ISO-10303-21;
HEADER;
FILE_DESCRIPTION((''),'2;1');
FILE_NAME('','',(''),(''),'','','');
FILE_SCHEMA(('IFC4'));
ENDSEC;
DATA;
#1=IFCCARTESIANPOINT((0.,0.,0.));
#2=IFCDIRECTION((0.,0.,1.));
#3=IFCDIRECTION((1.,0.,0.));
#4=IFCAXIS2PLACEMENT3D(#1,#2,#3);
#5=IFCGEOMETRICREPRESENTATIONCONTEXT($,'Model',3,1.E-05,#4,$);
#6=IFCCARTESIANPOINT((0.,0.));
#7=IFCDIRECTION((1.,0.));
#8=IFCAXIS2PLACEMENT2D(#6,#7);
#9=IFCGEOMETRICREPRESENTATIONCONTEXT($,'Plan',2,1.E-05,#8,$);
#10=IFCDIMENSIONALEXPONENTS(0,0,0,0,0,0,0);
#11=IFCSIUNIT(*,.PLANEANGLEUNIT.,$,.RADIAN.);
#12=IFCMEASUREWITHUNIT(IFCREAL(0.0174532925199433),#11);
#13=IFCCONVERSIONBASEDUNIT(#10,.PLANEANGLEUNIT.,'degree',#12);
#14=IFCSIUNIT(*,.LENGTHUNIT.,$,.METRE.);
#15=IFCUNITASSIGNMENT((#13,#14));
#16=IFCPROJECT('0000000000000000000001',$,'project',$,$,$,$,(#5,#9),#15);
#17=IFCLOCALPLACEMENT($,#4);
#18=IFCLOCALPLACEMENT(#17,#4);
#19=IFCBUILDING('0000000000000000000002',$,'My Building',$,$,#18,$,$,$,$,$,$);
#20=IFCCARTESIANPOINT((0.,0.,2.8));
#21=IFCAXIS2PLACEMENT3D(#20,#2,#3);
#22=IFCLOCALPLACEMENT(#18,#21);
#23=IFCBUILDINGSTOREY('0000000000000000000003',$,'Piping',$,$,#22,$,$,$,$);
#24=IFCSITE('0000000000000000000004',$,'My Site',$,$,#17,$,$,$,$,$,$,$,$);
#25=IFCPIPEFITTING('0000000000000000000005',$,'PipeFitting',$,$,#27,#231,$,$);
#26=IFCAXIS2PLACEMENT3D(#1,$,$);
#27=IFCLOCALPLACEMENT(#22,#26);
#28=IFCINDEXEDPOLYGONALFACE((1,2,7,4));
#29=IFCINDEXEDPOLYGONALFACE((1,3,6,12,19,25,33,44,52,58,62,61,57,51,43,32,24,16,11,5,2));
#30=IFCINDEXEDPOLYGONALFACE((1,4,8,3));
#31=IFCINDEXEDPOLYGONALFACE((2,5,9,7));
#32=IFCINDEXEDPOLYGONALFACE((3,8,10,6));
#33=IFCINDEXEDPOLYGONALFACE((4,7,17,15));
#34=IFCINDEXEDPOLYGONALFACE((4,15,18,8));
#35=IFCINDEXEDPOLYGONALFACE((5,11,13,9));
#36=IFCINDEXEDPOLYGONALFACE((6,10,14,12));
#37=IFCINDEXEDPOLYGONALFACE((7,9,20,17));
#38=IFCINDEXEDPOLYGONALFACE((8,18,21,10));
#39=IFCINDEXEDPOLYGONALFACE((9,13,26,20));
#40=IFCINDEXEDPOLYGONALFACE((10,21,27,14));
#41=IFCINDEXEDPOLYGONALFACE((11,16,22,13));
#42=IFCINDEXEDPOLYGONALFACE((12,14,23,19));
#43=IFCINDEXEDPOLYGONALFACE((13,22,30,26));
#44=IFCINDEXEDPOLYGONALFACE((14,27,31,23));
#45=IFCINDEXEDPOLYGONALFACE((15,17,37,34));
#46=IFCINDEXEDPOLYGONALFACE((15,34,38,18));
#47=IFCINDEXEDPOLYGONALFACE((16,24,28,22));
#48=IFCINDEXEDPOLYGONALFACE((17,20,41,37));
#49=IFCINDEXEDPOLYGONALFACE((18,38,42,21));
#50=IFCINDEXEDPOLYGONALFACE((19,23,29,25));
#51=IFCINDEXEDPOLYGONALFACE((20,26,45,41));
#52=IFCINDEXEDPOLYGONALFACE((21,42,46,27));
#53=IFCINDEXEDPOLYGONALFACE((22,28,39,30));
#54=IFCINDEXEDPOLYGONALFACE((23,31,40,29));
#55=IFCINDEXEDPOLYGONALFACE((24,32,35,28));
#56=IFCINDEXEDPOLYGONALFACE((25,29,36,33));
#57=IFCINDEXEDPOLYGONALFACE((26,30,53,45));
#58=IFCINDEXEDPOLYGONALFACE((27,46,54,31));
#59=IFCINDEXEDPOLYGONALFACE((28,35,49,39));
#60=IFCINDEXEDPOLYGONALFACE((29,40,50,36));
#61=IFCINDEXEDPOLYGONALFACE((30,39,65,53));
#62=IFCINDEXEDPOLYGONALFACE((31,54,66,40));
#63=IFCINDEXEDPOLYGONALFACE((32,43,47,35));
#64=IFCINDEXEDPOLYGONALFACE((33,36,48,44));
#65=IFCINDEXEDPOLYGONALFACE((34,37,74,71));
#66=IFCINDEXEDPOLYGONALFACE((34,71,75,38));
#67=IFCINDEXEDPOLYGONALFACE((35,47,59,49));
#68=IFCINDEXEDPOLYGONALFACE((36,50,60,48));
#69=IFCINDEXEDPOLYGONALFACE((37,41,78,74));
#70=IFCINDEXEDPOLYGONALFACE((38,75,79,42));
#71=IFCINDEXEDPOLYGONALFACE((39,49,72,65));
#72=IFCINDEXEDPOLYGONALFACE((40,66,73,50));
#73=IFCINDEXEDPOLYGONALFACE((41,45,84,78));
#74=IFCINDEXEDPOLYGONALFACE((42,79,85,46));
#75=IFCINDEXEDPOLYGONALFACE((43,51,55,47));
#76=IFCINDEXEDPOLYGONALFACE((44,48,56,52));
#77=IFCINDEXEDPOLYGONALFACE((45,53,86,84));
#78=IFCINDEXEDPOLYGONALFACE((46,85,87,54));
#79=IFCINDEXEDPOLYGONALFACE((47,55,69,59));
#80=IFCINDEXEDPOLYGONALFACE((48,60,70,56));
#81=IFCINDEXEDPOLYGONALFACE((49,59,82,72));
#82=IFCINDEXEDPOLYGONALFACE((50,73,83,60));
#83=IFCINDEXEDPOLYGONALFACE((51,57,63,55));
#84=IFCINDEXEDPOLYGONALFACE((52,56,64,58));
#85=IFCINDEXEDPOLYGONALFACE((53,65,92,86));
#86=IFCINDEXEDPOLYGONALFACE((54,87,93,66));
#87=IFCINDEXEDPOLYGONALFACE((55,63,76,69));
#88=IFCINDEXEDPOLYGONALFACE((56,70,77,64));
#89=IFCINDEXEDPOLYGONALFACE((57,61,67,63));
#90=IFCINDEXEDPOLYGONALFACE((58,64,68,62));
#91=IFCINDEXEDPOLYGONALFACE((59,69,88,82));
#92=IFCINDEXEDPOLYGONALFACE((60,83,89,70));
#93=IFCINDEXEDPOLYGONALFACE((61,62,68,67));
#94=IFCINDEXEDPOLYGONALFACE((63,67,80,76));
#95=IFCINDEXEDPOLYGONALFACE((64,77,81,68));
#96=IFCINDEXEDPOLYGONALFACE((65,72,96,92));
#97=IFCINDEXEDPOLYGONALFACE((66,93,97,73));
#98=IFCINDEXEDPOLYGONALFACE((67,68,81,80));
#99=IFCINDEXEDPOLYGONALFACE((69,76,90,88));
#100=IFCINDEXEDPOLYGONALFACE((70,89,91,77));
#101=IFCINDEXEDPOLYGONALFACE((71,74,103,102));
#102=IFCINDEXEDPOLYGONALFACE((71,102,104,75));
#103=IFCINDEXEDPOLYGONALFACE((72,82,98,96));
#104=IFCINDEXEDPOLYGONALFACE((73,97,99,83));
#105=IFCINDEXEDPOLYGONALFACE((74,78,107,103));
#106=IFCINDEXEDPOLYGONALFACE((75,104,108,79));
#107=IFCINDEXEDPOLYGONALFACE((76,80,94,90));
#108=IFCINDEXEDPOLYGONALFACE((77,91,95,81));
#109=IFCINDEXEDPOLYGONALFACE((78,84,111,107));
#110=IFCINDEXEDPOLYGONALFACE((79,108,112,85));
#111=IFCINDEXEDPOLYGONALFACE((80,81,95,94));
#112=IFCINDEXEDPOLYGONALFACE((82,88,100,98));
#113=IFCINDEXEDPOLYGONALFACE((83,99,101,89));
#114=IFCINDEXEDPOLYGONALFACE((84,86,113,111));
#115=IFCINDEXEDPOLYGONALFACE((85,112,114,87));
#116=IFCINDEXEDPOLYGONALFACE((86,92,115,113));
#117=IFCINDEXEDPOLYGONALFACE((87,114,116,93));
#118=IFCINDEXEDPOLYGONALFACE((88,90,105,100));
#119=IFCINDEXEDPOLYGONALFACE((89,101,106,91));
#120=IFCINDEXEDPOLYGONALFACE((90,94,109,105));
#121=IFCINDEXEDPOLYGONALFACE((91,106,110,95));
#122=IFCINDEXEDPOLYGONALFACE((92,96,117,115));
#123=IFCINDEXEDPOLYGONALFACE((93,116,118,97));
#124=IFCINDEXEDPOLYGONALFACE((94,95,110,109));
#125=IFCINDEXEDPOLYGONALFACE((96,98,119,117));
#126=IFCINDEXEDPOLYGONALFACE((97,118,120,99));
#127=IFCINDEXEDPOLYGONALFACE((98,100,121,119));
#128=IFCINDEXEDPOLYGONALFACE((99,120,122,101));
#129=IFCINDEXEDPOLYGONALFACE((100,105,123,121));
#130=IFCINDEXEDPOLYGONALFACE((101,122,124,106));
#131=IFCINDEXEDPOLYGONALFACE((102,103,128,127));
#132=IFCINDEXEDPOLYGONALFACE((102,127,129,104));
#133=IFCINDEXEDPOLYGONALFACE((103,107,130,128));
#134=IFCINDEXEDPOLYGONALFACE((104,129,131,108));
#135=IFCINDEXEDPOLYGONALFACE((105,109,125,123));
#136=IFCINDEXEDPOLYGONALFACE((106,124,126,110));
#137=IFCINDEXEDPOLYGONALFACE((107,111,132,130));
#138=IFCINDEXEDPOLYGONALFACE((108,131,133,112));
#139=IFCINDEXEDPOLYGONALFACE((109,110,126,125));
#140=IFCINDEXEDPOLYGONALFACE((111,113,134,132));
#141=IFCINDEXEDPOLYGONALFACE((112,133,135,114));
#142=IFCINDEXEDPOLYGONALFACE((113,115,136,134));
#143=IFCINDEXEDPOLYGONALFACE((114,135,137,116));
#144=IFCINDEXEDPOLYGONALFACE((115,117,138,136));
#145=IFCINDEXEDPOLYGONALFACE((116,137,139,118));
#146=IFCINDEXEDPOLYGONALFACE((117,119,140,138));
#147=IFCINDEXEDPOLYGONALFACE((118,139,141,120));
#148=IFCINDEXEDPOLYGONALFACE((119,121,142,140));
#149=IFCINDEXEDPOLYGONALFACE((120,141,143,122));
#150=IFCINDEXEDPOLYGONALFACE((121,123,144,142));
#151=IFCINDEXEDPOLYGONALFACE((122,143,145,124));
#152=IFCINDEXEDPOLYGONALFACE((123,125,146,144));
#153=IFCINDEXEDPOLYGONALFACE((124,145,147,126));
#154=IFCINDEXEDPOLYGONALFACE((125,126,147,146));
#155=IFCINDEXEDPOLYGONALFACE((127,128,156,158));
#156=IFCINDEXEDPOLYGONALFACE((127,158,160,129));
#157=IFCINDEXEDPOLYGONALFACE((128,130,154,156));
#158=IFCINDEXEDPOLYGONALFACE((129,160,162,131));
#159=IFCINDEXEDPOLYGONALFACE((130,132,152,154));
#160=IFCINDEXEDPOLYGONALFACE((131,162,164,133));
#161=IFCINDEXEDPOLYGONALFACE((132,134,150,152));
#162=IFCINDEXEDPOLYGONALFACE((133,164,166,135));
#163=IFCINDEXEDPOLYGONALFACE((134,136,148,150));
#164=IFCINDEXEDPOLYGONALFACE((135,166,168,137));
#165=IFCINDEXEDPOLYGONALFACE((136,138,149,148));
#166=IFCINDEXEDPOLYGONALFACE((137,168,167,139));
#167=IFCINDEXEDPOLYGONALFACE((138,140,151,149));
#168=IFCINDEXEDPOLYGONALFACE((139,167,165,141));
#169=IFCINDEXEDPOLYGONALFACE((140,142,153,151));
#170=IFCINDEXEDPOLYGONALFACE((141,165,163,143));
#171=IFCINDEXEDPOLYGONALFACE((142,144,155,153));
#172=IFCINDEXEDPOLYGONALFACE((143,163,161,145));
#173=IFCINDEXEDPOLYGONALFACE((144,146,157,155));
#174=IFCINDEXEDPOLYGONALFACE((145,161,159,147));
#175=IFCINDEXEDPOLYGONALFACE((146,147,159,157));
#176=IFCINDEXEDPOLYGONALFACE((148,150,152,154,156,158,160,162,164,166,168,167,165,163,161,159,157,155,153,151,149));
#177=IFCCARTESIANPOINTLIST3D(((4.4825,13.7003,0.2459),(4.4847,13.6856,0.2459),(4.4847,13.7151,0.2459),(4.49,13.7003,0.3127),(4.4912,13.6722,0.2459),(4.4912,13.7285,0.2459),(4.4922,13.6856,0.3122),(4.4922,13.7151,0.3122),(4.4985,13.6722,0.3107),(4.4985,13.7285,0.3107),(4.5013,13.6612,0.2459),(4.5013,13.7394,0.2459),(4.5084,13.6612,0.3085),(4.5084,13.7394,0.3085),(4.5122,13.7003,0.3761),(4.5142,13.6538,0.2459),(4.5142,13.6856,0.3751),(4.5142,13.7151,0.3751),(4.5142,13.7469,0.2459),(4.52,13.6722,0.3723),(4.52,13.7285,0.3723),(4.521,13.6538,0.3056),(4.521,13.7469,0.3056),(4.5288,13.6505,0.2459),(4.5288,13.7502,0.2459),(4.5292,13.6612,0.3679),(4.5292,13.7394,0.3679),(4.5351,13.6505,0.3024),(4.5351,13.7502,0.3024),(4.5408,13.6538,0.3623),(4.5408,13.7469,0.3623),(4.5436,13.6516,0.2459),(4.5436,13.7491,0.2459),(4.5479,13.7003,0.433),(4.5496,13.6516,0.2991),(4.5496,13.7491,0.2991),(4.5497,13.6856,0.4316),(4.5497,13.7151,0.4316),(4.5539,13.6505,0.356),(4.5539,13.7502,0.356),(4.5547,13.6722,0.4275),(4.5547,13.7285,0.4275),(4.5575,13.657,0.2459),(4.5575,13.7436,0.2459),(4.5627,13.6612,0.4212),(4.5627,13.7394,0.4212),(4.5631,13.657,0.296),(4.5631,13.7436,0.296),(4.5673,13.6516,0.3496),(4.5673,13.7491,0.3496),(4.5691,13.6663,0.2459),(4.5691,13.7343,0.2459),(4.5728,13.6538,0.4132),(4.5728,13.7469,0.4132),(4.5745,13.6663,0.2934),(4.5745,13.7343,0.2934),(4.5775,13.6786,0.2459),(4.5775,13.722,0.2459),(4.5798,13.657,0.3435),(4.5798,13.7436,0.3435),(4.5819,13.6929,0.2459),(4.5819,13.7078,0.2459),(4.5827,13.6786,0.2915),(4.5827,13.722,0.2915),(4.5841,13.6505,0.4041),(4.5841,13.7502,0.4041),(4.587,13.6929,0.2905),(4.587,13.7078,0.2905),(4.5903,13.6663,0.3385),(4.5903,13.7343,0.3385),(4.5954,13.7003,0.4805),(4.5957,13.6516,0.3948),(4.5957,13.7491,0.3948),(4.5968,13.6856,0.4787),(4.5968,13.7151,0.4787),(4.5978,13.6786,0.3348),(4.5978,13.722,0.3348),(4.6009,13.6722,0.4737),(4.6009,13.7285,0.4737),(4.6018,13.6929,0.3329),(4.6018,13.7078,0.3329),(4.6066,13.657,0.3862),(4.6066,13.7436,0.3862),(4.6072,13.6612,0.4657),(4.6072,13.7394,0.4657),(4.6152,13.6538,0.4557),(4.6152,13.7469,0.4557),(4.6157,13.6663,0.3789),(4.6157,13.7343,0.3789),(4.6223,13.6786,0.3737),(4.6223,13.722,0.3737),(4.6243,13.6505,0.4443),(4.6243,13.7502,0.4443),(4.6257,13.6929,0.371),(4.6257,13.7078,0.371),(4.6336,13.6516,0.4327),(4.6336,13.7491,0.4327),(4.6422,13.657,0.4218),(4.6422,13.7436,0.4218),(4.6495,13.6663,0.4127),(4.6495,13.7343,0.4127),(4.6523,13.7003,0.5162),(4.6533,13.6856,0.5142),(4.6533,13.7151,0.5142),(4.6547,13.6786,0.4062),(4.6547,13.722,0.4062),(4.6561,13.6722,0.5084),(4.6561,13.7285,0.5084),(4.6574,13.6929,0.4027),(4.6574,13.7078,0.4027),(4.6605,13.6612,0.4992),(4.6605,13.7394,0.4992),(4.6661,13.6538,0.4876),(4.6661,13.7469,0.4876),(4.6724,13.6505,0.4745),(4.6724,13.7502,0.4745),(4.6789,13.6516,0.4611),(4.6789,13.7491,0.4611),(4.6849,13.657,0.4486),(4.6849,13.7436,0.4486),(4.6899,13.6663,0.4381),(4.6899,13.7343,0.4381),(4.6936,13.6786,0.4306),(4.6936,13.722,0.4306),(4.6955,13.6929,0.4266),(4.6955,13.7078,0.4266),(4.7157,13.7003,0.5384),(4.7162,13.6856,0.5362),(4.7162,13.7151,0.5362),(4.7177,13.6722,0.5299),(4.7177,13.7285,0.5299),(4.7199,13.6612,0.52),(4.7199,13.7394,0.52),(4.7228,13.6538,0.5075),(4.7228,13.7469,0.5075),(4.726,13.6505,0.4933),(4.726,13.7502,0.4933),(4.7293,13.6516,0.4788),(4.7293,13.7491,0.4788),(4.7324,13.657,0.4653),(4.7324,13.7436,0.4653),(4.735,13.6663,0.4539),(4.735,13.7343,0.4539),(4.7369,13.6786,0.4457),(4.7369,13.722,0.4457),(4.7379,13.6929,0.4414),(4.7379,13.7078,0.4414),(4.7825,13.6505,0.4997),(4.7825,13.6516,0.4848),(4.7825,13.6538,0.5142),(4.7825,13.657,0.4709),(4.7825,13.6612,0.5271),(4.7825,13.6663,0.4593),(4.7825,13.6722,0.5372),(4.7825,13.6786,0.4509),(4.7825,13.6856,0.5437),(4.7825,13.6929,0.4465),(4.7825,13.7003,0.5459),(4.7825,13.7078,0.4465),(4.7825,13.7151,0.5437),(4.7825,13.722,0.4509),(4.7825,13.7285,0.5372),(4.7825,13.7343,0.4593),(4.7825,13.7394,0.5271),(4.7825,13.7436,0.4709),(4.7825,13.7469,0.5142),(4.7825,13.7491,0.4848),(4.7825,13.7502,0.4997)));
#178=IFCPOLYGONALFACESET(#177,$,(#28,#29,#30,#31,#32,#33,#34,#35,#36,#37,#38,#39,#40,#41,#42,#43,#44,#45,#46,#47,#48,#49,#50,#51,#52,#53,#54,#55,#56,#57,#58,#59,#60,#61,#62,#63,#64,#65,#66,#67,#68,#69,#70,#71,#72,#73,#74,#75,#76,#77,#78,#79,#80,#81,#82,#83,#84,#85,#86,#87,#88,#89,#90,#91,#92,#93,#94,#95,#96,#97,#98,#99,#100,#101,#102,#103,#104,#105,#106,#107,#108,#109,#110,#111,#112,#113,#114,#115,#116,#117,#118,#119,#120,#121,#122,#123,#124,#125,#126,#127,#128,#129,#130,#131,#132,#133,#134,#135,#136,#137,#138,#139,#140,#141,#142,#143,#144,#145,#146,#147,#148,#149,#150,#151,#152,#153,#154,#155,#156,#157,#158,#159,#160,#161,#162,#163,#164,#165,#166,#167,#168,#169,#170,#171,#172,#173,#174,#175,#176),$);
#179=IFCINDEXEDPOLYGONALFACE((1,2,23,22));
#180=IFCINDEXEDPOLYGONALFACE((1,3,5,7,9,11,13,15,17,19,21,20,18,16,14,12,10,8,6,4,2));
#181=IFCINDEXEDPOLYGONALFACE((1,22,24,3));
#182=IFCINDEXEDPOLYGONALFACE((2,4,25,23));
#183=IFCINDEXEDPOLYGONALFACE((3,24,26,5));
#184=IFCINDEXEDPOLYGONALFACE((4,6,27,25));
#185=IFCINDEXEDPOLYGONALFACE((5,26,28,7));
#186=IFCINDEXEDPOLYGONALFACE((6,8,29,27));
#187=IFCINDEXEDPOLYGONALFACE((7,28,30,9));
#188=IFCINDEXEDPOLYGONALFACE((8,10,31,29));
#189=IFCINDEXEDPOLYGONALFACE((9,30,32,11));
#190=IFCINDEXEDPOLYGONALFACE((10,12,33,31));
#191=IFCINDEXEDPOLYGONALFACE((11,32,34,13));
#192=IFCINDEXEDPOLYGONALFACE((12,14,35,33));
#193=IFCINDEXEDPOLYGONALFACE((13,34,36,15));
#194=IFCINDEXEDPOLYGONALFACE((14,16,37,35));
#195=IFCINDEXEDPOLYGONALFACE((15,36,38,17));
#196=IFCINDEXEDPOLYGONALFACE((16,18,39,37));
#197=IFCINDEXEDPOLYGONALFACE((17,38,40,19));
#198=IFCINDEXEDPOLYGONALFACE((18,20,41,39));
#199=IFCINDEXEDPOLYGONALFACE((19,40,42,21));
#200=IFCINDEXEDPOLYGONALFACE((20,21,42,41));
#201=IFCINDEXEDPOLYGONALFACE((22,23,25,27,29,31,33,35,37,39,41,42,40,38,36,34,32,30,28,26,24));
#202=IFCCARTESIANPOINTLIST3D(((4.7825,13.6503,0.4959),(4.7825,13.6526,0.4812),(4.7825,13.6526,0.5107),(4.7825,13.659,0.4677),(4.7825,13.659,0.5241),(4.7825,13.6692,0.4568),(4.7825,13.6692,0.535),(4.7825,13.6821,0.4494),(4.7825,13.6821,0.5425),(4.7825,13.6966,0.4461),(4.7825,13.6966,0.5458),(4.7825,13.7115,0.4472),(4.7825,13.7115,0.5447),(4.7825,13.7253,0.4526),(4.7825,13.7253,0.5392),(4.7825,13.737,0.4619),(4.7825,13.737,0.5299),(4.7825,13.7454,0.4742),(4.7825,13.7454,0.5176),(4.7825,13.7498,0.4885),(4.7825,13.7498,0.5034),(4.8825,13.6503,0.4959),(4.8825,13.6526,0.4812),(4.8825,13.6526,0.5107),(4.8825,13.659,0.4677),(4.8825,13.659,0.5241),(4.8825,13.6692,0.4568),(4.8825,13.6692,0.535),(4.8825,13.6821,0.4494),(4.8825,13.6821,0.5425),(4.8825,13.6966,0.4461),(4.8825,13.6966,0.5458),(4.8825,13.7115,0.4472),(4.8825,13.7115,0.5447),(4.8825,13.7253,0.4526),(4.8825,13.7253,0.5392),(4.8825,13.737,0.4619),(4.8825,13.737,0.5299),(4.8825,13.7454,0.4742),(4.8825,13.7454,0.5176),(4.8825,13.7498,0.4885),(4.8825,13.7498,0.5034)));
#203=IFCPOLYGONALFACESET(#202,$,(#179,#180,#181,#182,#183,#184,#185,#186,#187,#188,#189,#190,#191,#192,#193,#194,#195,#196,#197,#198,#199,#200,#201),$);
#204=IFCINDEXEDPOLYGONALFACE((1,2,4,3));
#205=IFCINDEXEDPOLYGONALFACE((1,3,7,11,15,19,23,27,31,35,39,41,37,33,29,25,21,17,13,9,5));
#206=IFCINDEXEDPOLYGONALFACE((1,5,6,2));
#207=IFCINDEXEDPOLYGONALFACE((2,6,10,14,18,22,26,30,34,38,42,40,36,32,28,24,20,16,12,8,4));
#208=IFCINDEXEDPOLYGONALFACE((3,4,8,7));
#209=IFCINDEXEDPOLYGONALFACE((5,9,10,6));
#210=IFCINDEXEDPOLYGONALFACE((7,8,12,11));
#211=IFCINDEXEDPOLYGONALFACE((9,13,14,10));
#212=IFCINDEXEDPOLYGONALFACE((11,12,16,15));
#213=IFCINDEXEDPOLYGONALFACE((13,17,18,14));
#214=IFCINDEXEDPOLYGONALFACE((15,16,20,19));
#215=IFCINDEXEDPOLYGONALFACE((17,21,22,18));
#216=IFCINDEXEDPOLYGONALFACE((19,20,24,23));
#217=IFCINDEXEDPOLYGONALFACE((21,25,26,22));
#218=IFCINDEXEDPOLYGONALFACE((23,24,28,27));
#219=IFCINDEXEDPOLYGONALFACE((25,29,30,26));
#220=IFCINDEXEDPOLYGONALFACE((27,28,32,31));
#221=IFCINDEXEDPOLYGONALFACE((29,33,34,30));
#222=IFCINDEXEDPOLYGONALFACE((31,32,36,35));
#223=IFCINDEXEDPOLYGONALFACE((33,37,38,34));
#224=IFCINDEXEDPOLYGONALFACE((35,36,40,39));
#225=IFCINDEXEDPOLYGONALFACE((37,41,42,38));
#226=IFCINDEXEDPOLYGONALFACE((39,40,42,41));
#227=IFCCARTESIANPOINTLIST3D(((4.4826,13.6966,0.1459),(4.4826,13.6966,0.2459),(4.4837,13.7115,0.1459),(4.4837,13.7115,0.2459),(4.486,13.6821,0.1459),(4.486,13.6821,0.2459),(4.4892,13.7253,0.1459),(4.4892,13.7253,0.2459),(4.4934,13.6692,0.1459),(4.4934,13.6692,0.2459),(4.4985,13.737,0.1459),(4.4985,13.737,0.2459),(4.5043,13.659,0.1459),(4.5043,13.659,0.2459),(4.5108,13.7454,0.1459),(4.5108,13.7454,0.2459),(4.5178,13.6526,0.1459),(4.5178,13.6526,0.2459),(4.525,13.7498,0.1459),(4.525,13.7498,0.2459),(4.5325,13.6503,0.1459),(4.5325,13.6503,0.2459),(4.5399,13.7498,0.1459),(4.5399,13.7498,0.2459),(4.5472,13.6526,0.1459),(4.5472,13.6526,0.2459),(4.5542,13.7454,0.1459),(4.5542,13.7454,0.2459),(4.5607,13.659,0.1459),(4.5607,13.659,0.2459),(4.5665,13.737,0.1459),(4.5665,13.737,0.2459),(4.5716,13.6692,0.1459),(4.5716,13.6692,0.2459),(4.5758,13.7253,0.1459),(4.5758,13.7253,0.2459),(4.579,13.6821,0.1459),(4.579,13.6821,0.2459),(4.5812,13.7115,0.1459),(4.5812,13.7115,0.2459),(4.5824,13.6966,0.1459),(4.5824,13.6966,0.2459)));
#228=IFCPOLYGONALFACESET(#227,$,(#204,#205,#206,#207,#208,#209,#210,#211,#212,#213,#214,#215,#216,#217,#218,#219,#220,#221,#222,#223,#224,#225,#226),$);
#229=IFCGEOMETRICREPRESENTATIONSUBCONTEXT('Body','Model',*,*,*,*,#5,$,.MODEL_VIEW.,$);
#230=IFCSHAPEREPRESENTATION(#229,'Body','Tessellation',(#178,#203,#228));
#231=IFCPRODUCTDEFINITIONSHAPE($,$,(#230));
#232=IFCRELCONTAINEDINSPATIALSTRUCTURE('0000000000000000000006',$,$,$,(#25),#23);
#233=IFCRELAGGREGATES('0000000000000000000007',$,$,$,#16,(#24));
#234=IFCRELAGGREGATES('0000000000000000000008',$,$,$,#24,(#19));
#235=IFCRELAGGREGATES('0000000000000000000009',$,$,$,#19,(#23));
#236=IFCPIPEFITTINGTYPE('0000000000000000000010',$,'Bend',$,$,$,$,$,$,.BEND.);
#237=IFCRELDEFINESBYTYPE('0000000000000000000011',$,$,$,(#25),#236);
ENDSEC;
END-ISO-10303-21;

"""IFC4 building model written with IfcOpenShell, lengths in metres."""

from ifc_helpers import new_model, entity, si_unit, converted_unit, frame, origin_with_axes, origin_2d_with_axis, place, context, subcontext, project, spatial, circle, extrude, source, transform, mapped, type_object, type_shapes, element, save


model = new_model("IFC4")

# Units and contexts
model_context = context("Model", 3, precision=1e-05, world=origin_with_axes())
plan_context = context("Plan", 2, precision=1e-05, world=origin_2d_with_axis())
body_context = subcontext(model_context, "Body", "Model", "MODEL_VIEW")
ifc_project = project(units=[converted_unit("PLANEANGLEUNIT", "degree", entity("IfcReal", 0.0174532925199433), si_unit("PLANEANGLEUNIT", "RADIAN"), dimensions=[0, 0, 0, 0, 0, 0, 0]), si_unit("LENGTHUNIT", "METRE")], contexts=[model_context, plan_context])

# Site, building, storey
site_placement = place(None, origin_with_axes())
site = spatial("IfcSite", under=ifc_project, at=site_placement, Name="My Site")
building_placement = place(site_placement, origin_with_axes())
building = spatial("IfcBuilding", under=site, at=building_placement, Name="My Building")
storey_placement = place(building_placement, frame((0.0, 0.0, 2.8), z_axis=(0.0, 0.0, 1.0), x_axis=(1.0, 0.0, 0.0)))
storey = spatial("IfcBuildingStorey", under=building, at=storey_placement, Name="Piping")

# Pipe fitting
pipe_fitting_type_1 = type_object("IfcPipeFittingType", Name="Bend", PredefinedType="BEND")
shared_shape_1 = source(origin_with_axes(), body_context, "Body", "SolidModel", [
    entity("IfcSweptDiskSolid", entity("IfcIndexedPolyCurve", entity("IfcCartesianPointList3D", [[0.0, 0.0, 0.1], [0.0, -0.0732, 0.2768], [0.0, -0.25, 0.35]]), [entity("IfcArcIndex", [1, 2, 3])]), 0.05),
    extrude(circle(Radius=0.05), origin_with_axes(), (0.0, 0.0, 1.0), 0.1),
    extrude(circle(Radius=0.05), frame((0.0, -0.25, 0.35), z_axis=(0.0, -1.0, 0.0), x_axis=(1.0, 0.0, 0.0)), (0.0, 0.0, 1.0), 0.1),
])
type_shapes(pipe_fitting_type_1, [shared_shape_1])
for number, where, z_axis, x_axis, name in (
    (1, (4.8825, 13.7003, 0.4959), (-1.0, 0.0, 0.0), (0.0, -1.0, 0.0), "PipeFitting"),
):
    element("IfcPipeFitting", number, at=place(storey_placement, frame(where, z_axis=z_axis, x_axis=x_axis)), inside=storey, type_object=pipe_fitting_type_1, Name=name, context=body_context, shape_type="MappedRepresentation", body=[
        mapped(shared_shape_1, transform((0.0, 0.0, 0.0), x_axis=(1.0, 0.0, 0.0), y_axis=(0.0, 1.0, 0.0), z_axis=(0.0, 0.0, 1.0), scale=1.0)),
    ])

save(model, "model.ifc")
